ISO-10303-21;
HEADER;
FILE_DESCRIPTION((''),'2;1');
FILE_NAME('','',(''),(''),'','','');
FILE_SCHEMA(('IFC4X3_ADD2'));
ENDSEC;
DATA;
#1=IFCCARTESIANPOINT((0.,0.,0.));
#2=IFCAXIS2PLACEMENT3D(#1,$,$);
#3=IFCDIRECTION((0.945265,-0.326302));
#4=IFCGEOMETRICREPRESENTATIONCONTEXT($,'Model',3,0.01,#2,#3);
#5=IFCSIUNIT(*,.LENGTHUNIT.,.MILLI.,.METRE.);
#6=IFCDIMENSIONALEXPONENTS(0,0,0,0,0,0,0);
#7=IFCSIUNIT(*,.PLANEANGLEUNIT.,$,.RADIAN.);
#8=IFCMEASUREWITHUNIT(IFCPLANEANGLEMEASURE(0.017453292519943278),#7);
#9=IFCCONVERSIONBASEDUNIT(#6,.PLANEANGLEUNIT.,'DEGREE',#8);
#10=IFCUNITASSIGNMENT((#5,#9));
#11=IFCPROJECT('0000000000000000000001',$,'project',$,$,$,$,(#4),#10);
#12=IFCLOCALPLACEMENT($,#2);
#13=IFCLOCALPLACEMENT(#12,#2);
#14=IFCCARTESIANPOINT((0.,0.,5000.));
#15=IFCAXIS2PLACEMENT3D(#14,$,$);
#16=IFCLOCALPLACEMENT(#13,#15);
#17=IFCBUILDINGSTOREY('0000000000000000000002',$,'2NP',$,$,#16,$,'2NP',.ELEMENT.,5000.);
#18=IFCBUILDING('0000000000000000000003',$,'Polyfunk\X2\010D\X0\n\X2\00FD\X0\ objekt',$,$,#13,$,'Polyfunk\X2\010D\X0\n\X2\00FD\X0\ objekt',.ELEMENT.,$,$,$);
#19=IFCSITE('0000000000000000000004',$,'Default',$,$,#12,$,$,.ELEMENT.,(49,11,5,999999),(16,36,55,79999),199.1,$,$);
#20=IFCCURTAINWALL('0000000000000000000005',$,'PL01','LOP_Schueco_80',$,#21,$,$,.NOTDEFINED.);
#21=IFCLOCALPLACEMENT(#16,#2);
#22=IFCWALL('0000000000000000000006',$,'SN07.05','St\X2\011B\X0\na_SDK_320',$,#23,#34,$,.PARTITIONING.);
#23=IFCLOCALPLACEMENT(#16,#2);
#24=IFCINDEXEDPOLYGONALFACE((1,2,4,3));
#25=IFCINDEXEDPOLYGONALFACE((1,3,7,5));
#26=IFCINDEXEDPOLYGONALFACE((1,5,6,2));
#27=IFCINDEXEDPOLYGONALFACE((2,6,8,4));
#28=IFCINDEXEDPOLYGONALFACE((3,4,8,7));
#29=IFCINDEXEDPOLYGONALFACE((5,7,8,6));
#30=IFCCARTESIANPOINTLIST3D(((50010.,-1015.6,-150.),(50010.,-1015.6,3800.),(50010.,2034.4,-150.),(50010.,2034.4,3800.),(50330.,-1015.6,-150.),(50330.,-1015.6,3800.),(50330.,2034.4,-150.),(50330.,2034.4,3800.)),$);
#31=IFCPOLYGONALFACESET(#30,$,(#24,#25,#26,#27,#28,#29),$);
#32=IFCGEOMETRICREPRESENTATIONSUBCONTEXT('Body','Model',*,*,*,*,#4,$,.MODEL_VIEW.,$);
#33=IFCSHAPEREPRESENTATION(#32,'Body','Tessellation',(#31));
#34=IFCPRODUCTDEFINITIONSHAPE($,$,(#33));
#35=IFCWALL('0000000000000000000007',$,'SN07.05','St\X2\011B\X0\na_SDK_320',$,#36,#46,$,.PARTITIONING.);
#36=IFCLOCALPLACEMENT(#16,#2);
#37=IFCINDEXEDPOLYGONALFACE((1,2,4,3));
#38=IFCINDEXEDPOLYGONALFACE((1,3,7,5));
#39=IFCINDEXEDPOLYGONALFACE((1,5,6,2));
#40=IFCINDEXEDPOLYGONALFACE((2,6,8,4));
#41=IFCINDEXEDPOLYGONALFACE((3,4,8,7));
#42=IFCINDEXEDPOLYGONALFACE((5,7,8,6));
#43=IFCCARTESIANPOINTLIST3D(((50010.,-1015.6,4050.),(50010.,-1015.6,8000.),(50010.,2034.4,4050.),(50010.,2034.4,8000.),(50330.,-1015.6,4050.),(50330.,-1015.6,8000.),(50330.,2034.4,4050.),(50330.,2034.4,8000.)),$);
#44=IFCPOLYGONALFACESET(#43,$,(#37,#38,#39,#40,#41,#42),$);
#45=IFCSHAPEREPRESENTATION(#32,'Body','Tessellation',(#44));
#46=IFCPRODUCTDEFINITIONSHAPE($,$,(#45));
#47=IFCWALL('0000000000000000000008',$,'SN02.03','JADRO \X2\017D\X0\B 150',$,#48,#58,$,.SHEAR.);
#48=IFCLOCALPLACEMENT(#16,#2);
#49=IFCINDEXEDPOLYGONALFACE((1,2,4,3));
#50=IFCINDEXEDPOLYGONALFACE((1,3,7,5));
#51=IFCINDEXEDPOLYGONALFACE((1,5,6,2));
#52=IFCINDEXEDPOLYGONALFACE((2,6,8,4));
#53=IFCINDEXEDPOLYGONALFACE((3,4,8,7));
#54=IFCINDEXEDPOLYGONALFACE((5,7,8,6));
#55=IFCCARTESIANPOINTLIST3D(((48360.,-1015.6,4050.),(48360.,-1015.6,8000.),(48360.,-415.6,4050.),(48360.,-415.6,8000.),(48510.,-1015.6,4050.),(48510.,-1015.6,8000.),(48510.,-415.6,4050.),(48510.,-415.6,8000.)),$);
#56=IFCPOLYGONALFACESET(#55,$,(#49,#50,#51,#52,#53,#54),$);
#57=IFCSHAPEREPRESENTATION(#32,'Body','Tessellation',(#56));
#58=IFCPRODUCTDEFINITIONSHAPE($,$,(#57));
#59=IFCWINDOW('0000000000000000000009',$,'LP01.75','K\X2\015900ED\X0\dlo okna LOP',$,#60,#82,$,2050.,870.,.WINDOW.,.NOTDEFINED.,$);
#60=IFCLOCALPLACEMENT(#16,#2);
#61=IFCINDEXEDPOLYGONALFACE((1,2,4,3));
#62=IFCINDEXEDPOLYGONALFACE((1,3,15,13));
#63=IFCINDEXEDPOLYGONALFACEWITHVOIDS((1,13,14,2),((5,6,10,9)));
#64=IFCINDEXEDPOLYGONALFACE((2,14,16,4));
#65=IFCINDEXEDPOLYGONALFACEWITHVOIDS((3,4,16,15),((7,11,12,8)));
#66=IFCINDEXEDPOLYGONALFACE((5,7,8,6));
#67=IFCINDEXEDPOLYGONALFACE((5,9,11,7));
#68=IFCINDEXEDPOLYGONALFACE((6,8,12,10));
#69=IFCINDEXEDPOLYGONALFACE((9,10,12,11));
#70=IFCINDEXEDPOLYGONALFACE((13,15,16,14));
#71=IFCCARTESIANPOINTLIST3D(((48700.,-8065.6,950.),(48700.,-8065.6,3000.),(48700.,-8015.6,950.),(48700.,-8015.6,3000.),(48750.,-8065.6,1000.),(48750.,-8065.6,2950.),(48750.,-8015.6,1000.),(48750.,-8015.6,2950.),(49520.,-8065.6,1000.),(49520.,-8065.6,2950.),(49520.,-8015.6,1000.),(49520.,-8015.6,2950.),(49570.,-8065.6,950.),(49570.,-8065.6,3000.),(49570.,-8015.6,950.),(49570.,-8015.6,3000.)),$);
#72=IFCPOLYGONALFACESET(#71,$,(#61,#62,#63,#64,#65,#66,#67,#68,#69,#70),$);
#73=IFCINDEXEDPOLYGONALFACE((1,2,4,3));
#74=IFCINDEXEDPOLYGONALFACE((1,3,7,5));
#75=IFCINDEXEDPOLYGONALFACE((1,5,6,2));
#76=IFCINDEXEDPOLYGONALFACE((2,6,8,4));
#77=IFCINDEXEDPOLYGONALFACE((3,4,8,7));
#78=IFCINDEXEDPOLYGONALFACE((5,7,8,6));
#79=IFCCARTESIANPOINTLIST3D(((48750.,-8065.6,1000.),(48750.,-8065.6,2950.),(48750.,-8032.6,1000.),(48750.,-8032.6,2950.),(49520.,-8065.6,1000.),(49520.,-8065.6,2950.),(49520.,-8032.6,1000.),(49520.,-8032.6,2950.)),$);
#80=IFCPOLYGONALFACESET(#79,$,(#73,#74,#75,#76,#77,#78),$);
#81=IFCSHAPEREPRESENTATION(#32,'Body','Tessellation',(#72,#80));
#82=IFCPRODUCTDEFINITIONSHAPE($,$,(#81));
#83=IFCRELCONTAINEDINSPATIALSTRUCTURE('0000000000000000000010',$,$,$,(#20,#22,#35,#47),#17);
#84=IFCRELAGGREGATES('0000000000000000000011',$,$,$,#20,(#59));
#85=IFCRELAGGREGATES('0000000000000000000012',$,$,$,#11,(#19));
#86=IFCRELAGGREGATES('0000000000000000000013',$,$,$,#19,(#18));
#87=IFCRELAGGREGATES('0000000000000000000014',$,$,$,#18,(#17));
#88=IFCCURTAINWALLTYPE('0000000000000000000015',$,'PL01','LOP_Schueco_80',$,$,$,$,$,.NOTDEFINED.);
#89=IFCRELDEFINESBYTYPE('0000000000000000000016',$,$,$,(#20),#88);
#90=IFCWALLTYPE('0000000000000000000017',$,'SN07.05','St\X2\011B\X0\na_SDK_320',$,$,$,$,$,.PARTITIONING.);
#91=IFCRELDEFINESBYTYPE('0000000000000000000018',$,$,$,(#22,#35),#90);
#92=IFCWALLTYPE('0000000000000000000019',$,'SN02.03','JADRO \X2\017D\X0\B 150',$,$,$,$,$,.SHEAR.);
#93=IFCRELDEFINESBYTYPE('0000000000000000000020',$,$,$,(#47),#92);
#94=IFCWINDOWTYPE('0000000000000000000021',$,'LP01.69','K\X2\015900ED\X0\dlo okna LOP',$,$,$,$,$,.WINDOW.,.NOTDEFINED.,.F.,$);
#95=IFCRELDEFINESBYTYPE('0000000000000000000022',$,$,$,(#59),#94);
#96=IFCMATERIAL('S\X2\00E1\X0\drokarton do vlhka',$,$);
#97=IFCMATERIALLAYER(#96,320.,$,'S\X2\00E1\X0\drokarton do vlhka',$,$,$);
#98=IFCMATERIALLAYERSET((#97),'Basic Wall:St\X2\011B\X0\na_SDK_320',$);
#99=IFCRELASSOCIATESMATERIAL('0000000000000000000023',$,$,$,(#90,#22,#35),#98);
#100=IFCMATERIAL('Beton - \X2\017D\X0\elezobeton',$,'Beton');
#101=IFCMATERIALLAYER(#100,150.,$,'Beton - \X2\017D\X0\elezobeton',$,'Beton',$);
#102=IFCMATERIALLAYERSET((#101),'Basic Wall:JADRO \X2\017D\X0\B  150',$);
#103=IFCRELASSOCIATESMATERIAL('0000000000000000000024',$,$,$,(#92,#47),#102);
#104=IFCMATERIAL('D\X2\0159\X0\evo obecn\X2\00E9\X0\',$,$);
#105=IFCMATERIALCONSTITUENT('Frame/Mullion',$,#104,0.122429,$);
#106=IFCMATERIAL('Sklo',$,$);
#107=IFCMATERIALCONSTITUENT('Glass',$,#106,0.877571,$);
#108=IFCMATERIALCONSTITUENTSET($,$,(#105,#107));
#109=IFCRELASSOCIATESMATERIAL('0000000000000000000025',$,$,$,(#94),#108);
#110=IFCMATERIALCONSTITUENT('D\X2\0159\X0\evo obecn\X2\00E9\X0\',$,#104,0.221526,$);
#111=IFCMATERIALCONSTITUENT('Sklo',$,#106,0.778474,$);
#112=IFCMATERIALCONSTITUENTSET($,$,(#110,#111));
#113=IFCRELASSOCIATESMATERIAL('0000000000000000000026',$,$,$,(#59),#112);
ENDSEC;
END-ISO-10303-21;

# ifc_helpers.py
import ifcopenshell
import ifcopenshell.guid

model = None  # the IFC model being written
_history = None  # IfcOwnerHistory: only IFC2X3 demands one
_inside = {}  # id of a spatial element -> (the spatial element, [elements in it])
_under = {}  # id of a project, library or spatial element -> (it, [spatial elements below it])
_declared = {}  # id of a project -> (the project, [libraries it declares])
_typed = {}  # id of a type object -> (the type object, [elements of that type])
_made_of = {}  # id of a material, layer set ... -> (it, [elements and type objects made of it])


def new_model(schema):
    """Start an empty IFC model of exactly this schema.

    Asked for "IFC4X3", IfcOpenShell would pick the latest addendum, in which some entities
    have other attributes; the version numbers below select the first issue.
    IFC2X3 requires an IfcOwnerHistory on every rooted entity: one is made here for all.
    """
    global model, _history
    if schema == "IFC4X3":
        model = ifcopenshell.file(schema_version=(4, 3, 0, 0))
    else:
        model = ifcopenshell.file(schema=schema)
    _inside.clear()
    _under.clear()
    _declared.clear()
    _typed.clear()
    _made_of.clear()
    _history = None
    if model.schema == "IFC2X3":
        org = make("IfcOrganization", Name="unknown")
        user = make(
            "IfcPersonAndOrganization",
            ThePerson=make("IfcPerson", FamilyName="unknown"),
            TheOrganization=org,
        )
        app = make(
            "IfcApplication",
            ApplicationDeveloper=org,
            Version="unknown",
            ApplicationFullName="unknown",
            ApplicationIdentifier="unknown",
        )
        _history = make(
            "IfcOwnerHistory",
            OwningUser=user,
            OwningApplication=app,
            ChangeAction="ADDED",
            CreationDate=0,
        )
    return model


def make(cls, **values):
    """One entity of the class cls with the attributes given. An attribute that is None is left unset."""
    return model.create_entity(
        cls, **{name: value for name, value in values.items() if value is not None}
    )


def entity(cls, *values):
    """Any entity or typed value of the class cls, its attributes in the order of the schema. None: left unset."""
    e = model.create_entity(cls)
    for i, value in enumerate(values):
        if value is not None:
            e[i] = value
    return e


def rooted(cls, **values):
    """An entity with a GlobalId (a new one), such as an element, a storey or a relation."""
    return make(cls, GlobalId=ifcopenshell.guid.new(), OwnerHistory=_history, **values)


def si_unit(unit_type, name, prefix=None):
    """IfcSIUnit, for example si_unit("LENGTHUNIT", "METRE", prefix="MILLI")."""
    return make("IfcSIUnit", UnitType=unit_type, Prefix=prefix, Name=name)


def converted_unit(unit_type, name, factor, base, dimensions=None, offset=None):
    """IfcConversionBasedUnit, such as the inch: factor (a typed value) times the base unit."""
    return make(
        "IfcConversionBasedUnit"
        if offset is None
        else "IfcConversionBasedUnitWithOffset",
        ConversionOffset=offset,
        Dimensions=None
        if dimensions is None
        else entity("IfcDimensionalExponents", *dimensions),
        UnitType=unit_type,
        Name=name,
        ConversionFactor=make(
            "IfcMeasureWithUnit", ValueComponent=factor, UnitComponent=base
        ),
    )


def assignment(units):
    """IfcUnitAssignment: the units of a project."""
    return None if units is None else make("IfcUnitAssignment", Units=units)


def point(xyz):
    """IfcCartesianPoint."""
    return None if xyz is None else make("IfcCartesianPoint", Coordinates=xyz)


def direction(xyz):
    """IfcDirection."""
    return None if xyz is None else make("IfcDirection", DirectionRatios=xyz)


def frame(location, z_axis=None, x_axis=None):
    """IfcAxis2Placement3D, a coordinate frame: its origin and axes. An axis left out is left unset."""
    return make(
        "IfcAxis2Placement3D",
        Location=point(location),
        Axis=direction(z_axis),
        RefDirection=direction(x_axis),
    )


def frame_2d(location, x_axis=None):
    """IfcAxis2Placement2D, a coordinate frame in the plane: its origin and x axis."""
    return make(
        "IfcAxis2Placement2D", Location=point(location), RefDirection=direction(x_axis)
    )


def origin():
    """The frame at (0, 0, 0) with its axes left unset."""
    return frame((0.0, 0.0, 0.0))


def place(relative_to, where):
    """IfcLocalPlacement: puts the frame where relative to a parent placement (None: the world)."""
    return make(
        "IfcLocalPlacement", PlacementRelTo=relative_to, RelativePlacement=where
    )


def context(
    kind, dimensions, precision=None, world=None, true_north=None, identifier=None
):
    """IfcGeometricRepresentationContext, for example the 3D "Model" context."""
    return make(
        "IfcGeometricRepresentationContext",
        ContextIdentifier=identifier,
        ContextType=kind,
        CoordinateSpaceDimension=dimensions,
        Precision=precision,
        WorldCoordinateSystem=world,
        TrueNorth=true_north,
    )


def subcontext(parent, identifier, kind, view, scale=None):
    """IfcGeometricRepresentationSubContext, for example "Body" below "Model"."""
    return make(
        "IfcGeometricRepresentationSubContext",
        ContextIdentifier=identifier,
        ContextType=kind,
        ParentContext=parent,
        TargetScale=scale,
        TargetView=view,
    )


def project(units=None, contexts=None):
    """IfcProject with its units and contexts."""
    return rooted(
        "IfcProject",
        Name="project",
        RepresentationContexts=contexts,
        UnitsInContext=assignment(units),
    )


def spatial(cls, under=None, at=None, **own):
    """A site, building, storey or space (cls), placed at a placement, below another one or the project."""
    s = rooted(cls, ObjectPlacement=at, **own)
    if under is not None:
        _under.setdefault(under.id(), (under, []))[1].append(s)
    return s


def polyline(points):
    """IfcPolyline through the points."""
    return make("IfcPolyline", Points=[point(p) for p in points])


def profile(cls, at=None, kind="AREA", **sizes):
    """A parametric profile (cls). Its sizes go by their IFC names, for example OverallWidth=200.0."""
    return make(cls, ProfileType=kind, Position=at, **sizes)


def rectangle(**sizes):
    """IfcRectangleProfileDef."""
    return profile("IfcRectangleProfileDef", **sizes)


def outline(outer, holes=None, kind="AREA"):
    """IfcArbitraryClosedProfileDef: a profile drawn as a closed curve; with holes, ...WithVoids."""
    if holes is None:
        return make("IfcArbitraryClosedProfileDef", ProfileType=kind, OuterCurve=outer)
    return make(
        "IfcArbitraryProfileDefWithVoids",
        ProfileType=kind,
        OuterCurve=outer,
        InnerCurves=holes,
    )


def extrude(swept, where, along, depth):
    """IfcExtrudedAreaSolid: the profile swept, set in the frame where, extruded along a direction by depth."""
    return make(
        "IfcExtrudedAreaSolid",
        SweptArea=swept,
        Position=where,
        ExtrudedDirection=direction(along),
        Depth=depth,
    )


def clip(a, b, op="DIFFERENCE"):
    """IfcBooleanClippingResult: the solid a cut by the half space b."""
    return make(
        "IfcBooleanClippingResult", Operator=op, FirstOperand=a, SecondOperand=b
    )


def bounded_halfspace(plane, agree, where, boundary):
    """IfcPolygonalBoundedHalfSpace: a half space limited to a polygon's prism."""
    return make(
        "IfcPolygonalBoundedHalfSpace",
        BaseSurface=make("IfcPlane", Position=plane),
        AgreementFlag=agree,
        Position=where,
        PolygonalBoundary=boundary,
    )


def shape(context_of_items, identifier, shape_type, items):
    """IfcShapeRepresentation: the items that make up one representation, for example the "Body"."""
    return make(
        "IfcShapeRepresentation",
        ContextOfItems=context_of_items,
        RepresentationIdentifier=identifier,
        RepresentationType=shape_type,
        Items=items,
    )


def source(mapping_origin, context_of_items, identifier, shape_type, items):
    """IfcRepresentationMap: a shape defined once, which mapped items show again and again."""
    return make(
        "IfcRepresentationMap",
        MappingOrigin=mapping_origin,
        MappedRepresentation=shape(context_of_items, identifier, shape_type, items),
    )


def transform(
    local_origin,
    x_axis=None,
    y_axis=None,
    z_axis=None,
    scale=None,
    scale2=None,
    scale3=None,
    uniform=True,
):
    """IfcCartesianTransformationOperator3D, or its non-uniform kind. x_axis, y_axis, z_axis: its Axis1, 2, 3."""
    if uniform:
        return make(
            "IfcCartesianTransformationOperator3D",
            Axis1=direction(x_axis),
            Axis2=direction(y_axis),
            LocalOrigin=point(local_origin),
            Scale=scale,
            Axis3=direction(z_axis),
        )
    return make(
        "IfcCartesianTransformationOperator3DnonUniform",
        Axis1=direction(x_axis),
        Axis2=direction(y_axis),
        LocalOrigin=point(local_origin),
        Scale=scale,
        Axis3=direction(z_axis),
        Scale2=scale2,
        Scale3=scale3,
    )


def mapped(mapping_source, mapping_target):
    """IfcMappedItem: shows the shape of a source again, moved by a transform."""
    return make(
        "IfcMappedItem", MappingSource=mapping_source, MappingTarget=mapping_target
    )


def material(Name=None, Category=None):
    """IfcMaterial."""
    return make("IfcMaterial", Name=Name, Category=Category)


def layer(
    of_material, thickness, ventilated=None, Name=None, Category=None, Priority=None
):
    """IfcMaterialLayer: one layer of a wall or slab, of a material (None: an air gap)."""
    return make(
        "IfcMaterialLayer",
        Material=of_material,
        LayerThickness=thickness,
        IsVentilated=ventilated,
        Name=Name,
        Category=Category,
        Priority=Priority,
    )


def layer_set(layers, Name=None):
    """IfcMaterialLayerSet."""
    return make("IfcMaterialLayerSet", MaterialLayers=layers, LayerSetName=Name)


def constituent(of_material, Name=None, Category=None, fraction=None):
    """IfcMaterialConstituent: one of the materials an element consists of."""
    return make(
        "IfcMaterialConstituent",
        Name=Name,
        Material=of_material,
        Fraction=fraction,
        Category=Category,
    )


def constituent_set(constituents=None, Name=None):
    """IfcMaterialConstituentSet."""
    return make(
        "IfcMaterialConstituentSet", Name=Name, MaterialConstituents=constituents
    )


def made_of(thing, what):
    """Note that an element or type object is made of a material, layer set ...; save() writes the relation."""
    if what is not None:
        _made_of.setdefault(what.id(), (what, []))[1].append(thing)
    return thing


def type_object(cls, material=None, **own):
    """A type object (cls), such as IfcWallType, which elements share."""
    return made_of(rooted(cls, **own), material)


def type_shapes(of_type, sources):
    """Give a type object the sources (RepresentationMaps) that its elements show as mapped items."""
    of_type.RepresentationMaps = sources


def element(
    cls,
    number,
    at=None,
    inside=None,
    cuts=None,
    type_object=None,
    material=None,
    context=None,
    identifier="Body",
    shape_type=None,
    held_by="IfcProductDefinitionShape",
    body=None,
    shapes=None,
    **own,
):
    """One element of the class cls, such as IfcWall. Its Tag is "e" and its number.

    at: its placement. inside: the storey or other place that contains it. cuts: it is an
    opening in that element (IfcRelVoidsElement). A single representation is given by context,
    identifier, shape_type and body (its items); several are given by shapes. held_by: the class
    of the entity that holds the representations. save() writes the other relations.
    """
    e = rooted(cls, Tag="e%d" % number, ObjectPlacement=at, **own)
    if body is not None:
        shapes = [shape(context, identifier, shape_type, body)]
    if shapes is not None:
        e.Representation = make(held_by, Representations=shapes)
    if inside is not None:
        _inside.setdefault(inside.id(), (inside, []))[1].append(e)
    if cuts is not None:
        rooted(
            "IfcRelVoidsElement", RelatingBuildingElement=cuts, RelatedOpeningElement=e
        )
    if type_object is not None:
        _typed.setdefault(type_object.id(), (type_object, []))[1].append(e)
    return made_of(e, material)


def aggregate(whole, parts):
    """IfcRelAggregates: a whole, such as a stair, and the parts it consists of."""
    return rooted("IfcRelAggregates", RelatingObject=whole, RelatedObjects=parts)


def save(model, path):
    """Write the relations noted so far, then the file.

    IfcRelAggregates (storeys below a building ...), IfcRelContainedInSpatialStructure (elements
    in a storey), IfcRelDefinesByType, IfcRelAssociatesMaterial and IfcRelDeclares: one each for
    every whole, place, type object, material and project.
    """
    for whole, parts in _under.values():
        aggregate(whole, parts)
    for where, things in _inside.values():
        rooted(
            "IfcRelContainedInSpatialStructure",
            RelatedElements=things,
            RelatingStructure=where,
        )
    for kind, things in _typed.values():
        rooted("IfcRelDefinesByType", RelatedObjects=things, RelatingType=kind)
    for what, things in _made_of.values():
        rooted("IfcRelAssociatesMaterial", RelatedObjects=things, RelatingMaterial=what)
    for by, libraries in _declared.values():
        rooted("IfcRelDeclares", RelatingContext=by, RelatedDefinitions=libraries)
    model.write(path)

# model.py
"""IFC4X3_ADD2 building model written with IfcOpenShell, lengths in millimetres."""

from ifc_helpers import new_model, entity, si_unit, converted_unit, direction, frame, frame_2d, origin, place, context, subcontext, project, spatial, polyline, rectangle, outline, extrude, clip, bounded_halfspace, source, transform, mapped, material, layer, layer_set, constituent, constituent_set, type_object, type_shapes, element, aggregate, save


model = new_model("IFC4X3_ADD2")

# Units and contexts
model_context = context("Model", 3, precision=0.01, world=origin(), true_north=direction((0.945265, -0.326302)))
body_context = subcontext(model_context, "Body", "Model", "MODEL_VIEW")
ifc_project = project(units=[si_unit("LENGTHUNIT", "METRE", prefix="MILLI"), converted_unit("PLANEANGLEUNIT", "DEGREE", entity("IfcPlaneAngleMeasure", 0.017453292519943278), si_unit("PLANEANGLEUNIT", "RADIAN"), dimensions=[0, 0, 0, 0, 0, 0, 0])], contexts=[model_context])

# Site, building, storey
site_placement = place(None, origin())
site = spatial("IfcSite", under=ifc_project, at=site_placement, Name="Default", CompositionType="ELEMENT", RefLatitude=(49, 11, 5, 999999), RefLongitude=(16, 36, 55, 79999), RefElevation=199.1)
building_placement = place(site_placement, origin())
building = spatial("IfcBuilding", under=site, at=building_placement, Name="Polyfunkčný objekt", LongName="Polyfunkčný objekt", CompositionType="ELEMENT")
storey_placement = place(building_placement, frame((0.0, 0.0, 5000.0)))
storey = spatial("IfcBuildingStorey", under=building, at=storey_placement, Name="2NP", LongName="2NP", CompositionType="ELEMENT", Elevation=5000.0)

# Curtain wall
curtain_wall_type = type_object("IfcCurtainWallType", Name="PL01", Description="LOP_Schueco_80", PredefinedType="NOTDEFINED")
curtain_wall_placement = place(storey_placement, frame((0.0, 0.0, -5000.0)))
curtain_wall = element("IfcCurtainWall", 1, at=curtain_wall_placement, inside=storey, type_object=curtain_wall_type, Name="PL01", Description="LOP_Schueco_80", PredefinedType="NOTDEFINED")
ifc_material_1 = material(Name="Sklo")

# Walls
ifc_material_2 = material(Name="Sádrokarton do vlhka")
ifc_layer_1 = layer(ifc_material_2, 320.0, Name="Sádrokarton do vlhka")
ifc_layer_set_1 = layer_set([ifc_layer_1], Name="Basic Wall:Stěna_SDK_320")
wall_type_1 = type_object("IfcWallType", Name="SN07.05", Description="Stěna_SDK_320", PredefinedType="PARTITIONING", material=ifc_layer_set_1)
wall_1_placement = place(storey_placement, frame((50170.0, 2034.4, -150.0), z_axis=(0.0, 0.0, 1.0), x_axis=(0.0, -1.0, 0.0)))
element("IfcWall", 2, at=wall_1_placement, inside=storey, type_object=wall_type_1, material=ifc_layer_set_1, Name="SN07.05", Description="Stěna_SDK_320", PredefinedType="PARTITIONING", context=body_context, shape_type="Clipping", body=[
    clip(clip(extrude(rectangle(XDim=3050.0, YDim=320.0, at=frame_2d((1525.0, 0.0), x_axis=(-1.0, 0.0))), origin(), (0.0, 0.0, 1.0), 3950.0), bounded_halfspace(frame((3050.0, -160.0, 0.0), z_axis=(0.0, 0.0, 1.0), x_axis=(0.0, -1.0, 0.0)), True, frame((3050.0, -160.0, 0.0)), polyline([(0.0, 0.0), (0.0, 320.0), (-1600.0, 320.0), (-1750.0, 320.0), (-2900.0, 320.0), (-3050.0, 320.0), (-3050.0, 0.0), (0.0, 0.0)]))), bounded_halfspace(frame((0.0, -160.0, 3950.0), z_axis=(0.0, 0.0, -1.0), x_axis=(0.0, 1.0, 0.0)), True, frame((0.0, -160.0, 3950.0)), polyline([(0.0, 0.0), (3050.0, 0.0), (3050.0, 320.0), (1450.0, 320.0), (1300.0, 320.0), (150.0, 320.0), (0.0, 320.0), (0.0, 0.0)]))),
])
wall_2_placement = place(storey_placement, frame((50170.0, 2034.4, 4050.0), z_axis=(0.0, 0.0, 1.0), x_axis=(0.0, -1.0, 0.0)))
element("IfcWall", 3, at=wall_2_placement, inside=storey, type_object=wall_type_1, material=ifc_layer_set_1, Name="SN07.05", Description="Stěna_SDK_320", PredefinedType="PARTITIONING", context=body_context, shape_type="Clipping", body=[
    clip(clip(extrude(rectangle(XDim=3050.0, YDim=320.0, at=frame_2d((1525.0, 0.0), x_axis=(-1.0, 0.0))), origin(), (0.0, 0.0, 1.0), 3950.0), bounded_halfspace(frame((3050.0, -160.0, 0.0), z_axis=(0.0, 0.0, 1.0), x_axis=(0.0, -1.0, 0.0)), True, frame((3050.0, -160.0, 0.0)), polyline([(0.0, 0.0), (0.0, 320.0), (-1600.0, 320.0), (-1750.0, 320.0), (-2900.0, 320.0), (-3050.0, 320.0), (-3050.0, 0.0), (0.0, 0.0)]))), bounded_halfspace(frame((0.0, -160.0, 3950.0), z_axis=(0.0, 0.0, -1.0), x_axis=(0.0, 1.0, 0.0)), True, frame((0.0, -160.0, 3950.0)), polyline([(0.0, 0.0), (3050.0, 0.0), (3050.0, 320.0), (1450.0, 320.0), (1300.0, 320.0), (150.0, 320.0), (0.0, 320.0), (0.0, 0.0)]))),
])
ifc_material_3 = material(Name="Beton - Železobeton", Category="Beton")
ifc_layer_2 = layer(ifc_material_3, 150.0, Name="Beton - Železobeton", Category="Beton")
ifc_layer_set_2 = layer_set([ifc_layer_2], Name="Basic Wall:JADRO ŽB  150")
wall_type_2 = type_object("IfcWallType", Name="SN02.03", Description="JADRO ŽB 150", PredefinedType="SHEAR", material=ifc_layer_set_2)
wall_3_placement = place(storey_placement, frame((48435.0, -1015.6, 4050.0), z_axis=(0.0, 0.0, 1.0), x_axis=(0.0, 1.0, 0.0)))
element("IfcWall", 4, at=wall_3_placement, inside=storey, type_object=wall_type_2, material=ifc_layer_set_2, Name="SN02.03", Description="JADRO ŽB 150", PredefinedType="SHEAR", context=body_context, shape_type="SweptSolid", body=[
    extrude(rectangle(XDim=600.0, YDim=150.0, at=frame_2d((300.0, 0.0), x_axis=(-1.0, 0.0))), origin(), (0.0, 0.0, 1.0), 3950.0),
])

# Window
ifc_material_4 = material(Name="Dřevo obecné")
ifc_constituent_1 = constituent(ifc_material_4, Name="Dřevo obecné", fraction=0.221526)
ifc_constituent_2 = constituent(ifc_material_1, Name="Sklo", fraction=0.778474)
ifc_constituent_set_1 = constituent_set(constituents=[ifc_constituent_1, ifc_constituent_2])
ifc_constituent_3 = constituent(ifc_material_4, Name="Frame/Mullion", fraction=0.122429)
ifc_constituent_4 = constituent(ifc_material_1, Name="Glass", fraction=0.877571)
ifc_constituent_set_2 = constituent_set(constituents=[ifc_constituent_3, ifc_constituent_4])
window_type = type_object("IfcWindowType", Name="LP01.69", Description="Křídlo okna LOP", ParameterTakesPrecedence=False, PartitioningType="NOTDEFINED", PredefinedType="WINDOW", material=ifc_constituent_set_2)
shared_shape_1 = source(origin(), body_context, "Body", "SweptSolid", [
    extrude(outline(polyline([(-1025.0, -435.0), (1025.0, -435.0), (1025.0, 435.0), (-1025.0, 435.0), (-1025.0, -435.0)]), holes=[polyline([(-975.0, -385.0), (-975.0, 385.0), (975.0, 385.0), (975.0, -385.0), (-975.0, -385.0)])]), frame((0.0, 50.0, 1025.0), z_axis=(0.0, -1.0, 0.0), x_axis=(0.0, 0.0, -1.0)), (0.0, 0.0, 1.0), 50.0),
    extrude(rectangle(XDim=770.0, YDim=33.0, at=frame_2d((0.0, 0.0), x_axis=(1.0, 0.0))), frame((0.0, 33.5, 50.0), z_axis=(0.0, 0.0, 1.0), x_axis=(-1.0, 0.0, 0.0)), (0.0, 0.0, 1.0), 1950.0),
])
type_shapes(window_type, [shared_shape_1])
window_placement = place(curtain_wall_placement, frame((49135.0, -8015.6, 5950.0), z_axis=(0.0, 0.0, 1.0), x_axis=(-1.0, 0.0, 0.0)))
window = element("IfcWindow", 5, at=window_placement, type_object=window_type, material=ifc_constituent_set_1, Name="LP01.75", Description="Křídlo okna LOP", OverallHeight=2050.0, OverallWidth=870.0, PartitioningType="NOTDEFINED", PredefinedType="WINDOW", context=body_context, shape_type="MappedRepresentation", body=[
    mapped(shared_shape_1, transform((0.0, 0.0, 0.0), scale=1.0)),
])
aggregate(curtain_wall, [window])

save(model, "model.ifc")
